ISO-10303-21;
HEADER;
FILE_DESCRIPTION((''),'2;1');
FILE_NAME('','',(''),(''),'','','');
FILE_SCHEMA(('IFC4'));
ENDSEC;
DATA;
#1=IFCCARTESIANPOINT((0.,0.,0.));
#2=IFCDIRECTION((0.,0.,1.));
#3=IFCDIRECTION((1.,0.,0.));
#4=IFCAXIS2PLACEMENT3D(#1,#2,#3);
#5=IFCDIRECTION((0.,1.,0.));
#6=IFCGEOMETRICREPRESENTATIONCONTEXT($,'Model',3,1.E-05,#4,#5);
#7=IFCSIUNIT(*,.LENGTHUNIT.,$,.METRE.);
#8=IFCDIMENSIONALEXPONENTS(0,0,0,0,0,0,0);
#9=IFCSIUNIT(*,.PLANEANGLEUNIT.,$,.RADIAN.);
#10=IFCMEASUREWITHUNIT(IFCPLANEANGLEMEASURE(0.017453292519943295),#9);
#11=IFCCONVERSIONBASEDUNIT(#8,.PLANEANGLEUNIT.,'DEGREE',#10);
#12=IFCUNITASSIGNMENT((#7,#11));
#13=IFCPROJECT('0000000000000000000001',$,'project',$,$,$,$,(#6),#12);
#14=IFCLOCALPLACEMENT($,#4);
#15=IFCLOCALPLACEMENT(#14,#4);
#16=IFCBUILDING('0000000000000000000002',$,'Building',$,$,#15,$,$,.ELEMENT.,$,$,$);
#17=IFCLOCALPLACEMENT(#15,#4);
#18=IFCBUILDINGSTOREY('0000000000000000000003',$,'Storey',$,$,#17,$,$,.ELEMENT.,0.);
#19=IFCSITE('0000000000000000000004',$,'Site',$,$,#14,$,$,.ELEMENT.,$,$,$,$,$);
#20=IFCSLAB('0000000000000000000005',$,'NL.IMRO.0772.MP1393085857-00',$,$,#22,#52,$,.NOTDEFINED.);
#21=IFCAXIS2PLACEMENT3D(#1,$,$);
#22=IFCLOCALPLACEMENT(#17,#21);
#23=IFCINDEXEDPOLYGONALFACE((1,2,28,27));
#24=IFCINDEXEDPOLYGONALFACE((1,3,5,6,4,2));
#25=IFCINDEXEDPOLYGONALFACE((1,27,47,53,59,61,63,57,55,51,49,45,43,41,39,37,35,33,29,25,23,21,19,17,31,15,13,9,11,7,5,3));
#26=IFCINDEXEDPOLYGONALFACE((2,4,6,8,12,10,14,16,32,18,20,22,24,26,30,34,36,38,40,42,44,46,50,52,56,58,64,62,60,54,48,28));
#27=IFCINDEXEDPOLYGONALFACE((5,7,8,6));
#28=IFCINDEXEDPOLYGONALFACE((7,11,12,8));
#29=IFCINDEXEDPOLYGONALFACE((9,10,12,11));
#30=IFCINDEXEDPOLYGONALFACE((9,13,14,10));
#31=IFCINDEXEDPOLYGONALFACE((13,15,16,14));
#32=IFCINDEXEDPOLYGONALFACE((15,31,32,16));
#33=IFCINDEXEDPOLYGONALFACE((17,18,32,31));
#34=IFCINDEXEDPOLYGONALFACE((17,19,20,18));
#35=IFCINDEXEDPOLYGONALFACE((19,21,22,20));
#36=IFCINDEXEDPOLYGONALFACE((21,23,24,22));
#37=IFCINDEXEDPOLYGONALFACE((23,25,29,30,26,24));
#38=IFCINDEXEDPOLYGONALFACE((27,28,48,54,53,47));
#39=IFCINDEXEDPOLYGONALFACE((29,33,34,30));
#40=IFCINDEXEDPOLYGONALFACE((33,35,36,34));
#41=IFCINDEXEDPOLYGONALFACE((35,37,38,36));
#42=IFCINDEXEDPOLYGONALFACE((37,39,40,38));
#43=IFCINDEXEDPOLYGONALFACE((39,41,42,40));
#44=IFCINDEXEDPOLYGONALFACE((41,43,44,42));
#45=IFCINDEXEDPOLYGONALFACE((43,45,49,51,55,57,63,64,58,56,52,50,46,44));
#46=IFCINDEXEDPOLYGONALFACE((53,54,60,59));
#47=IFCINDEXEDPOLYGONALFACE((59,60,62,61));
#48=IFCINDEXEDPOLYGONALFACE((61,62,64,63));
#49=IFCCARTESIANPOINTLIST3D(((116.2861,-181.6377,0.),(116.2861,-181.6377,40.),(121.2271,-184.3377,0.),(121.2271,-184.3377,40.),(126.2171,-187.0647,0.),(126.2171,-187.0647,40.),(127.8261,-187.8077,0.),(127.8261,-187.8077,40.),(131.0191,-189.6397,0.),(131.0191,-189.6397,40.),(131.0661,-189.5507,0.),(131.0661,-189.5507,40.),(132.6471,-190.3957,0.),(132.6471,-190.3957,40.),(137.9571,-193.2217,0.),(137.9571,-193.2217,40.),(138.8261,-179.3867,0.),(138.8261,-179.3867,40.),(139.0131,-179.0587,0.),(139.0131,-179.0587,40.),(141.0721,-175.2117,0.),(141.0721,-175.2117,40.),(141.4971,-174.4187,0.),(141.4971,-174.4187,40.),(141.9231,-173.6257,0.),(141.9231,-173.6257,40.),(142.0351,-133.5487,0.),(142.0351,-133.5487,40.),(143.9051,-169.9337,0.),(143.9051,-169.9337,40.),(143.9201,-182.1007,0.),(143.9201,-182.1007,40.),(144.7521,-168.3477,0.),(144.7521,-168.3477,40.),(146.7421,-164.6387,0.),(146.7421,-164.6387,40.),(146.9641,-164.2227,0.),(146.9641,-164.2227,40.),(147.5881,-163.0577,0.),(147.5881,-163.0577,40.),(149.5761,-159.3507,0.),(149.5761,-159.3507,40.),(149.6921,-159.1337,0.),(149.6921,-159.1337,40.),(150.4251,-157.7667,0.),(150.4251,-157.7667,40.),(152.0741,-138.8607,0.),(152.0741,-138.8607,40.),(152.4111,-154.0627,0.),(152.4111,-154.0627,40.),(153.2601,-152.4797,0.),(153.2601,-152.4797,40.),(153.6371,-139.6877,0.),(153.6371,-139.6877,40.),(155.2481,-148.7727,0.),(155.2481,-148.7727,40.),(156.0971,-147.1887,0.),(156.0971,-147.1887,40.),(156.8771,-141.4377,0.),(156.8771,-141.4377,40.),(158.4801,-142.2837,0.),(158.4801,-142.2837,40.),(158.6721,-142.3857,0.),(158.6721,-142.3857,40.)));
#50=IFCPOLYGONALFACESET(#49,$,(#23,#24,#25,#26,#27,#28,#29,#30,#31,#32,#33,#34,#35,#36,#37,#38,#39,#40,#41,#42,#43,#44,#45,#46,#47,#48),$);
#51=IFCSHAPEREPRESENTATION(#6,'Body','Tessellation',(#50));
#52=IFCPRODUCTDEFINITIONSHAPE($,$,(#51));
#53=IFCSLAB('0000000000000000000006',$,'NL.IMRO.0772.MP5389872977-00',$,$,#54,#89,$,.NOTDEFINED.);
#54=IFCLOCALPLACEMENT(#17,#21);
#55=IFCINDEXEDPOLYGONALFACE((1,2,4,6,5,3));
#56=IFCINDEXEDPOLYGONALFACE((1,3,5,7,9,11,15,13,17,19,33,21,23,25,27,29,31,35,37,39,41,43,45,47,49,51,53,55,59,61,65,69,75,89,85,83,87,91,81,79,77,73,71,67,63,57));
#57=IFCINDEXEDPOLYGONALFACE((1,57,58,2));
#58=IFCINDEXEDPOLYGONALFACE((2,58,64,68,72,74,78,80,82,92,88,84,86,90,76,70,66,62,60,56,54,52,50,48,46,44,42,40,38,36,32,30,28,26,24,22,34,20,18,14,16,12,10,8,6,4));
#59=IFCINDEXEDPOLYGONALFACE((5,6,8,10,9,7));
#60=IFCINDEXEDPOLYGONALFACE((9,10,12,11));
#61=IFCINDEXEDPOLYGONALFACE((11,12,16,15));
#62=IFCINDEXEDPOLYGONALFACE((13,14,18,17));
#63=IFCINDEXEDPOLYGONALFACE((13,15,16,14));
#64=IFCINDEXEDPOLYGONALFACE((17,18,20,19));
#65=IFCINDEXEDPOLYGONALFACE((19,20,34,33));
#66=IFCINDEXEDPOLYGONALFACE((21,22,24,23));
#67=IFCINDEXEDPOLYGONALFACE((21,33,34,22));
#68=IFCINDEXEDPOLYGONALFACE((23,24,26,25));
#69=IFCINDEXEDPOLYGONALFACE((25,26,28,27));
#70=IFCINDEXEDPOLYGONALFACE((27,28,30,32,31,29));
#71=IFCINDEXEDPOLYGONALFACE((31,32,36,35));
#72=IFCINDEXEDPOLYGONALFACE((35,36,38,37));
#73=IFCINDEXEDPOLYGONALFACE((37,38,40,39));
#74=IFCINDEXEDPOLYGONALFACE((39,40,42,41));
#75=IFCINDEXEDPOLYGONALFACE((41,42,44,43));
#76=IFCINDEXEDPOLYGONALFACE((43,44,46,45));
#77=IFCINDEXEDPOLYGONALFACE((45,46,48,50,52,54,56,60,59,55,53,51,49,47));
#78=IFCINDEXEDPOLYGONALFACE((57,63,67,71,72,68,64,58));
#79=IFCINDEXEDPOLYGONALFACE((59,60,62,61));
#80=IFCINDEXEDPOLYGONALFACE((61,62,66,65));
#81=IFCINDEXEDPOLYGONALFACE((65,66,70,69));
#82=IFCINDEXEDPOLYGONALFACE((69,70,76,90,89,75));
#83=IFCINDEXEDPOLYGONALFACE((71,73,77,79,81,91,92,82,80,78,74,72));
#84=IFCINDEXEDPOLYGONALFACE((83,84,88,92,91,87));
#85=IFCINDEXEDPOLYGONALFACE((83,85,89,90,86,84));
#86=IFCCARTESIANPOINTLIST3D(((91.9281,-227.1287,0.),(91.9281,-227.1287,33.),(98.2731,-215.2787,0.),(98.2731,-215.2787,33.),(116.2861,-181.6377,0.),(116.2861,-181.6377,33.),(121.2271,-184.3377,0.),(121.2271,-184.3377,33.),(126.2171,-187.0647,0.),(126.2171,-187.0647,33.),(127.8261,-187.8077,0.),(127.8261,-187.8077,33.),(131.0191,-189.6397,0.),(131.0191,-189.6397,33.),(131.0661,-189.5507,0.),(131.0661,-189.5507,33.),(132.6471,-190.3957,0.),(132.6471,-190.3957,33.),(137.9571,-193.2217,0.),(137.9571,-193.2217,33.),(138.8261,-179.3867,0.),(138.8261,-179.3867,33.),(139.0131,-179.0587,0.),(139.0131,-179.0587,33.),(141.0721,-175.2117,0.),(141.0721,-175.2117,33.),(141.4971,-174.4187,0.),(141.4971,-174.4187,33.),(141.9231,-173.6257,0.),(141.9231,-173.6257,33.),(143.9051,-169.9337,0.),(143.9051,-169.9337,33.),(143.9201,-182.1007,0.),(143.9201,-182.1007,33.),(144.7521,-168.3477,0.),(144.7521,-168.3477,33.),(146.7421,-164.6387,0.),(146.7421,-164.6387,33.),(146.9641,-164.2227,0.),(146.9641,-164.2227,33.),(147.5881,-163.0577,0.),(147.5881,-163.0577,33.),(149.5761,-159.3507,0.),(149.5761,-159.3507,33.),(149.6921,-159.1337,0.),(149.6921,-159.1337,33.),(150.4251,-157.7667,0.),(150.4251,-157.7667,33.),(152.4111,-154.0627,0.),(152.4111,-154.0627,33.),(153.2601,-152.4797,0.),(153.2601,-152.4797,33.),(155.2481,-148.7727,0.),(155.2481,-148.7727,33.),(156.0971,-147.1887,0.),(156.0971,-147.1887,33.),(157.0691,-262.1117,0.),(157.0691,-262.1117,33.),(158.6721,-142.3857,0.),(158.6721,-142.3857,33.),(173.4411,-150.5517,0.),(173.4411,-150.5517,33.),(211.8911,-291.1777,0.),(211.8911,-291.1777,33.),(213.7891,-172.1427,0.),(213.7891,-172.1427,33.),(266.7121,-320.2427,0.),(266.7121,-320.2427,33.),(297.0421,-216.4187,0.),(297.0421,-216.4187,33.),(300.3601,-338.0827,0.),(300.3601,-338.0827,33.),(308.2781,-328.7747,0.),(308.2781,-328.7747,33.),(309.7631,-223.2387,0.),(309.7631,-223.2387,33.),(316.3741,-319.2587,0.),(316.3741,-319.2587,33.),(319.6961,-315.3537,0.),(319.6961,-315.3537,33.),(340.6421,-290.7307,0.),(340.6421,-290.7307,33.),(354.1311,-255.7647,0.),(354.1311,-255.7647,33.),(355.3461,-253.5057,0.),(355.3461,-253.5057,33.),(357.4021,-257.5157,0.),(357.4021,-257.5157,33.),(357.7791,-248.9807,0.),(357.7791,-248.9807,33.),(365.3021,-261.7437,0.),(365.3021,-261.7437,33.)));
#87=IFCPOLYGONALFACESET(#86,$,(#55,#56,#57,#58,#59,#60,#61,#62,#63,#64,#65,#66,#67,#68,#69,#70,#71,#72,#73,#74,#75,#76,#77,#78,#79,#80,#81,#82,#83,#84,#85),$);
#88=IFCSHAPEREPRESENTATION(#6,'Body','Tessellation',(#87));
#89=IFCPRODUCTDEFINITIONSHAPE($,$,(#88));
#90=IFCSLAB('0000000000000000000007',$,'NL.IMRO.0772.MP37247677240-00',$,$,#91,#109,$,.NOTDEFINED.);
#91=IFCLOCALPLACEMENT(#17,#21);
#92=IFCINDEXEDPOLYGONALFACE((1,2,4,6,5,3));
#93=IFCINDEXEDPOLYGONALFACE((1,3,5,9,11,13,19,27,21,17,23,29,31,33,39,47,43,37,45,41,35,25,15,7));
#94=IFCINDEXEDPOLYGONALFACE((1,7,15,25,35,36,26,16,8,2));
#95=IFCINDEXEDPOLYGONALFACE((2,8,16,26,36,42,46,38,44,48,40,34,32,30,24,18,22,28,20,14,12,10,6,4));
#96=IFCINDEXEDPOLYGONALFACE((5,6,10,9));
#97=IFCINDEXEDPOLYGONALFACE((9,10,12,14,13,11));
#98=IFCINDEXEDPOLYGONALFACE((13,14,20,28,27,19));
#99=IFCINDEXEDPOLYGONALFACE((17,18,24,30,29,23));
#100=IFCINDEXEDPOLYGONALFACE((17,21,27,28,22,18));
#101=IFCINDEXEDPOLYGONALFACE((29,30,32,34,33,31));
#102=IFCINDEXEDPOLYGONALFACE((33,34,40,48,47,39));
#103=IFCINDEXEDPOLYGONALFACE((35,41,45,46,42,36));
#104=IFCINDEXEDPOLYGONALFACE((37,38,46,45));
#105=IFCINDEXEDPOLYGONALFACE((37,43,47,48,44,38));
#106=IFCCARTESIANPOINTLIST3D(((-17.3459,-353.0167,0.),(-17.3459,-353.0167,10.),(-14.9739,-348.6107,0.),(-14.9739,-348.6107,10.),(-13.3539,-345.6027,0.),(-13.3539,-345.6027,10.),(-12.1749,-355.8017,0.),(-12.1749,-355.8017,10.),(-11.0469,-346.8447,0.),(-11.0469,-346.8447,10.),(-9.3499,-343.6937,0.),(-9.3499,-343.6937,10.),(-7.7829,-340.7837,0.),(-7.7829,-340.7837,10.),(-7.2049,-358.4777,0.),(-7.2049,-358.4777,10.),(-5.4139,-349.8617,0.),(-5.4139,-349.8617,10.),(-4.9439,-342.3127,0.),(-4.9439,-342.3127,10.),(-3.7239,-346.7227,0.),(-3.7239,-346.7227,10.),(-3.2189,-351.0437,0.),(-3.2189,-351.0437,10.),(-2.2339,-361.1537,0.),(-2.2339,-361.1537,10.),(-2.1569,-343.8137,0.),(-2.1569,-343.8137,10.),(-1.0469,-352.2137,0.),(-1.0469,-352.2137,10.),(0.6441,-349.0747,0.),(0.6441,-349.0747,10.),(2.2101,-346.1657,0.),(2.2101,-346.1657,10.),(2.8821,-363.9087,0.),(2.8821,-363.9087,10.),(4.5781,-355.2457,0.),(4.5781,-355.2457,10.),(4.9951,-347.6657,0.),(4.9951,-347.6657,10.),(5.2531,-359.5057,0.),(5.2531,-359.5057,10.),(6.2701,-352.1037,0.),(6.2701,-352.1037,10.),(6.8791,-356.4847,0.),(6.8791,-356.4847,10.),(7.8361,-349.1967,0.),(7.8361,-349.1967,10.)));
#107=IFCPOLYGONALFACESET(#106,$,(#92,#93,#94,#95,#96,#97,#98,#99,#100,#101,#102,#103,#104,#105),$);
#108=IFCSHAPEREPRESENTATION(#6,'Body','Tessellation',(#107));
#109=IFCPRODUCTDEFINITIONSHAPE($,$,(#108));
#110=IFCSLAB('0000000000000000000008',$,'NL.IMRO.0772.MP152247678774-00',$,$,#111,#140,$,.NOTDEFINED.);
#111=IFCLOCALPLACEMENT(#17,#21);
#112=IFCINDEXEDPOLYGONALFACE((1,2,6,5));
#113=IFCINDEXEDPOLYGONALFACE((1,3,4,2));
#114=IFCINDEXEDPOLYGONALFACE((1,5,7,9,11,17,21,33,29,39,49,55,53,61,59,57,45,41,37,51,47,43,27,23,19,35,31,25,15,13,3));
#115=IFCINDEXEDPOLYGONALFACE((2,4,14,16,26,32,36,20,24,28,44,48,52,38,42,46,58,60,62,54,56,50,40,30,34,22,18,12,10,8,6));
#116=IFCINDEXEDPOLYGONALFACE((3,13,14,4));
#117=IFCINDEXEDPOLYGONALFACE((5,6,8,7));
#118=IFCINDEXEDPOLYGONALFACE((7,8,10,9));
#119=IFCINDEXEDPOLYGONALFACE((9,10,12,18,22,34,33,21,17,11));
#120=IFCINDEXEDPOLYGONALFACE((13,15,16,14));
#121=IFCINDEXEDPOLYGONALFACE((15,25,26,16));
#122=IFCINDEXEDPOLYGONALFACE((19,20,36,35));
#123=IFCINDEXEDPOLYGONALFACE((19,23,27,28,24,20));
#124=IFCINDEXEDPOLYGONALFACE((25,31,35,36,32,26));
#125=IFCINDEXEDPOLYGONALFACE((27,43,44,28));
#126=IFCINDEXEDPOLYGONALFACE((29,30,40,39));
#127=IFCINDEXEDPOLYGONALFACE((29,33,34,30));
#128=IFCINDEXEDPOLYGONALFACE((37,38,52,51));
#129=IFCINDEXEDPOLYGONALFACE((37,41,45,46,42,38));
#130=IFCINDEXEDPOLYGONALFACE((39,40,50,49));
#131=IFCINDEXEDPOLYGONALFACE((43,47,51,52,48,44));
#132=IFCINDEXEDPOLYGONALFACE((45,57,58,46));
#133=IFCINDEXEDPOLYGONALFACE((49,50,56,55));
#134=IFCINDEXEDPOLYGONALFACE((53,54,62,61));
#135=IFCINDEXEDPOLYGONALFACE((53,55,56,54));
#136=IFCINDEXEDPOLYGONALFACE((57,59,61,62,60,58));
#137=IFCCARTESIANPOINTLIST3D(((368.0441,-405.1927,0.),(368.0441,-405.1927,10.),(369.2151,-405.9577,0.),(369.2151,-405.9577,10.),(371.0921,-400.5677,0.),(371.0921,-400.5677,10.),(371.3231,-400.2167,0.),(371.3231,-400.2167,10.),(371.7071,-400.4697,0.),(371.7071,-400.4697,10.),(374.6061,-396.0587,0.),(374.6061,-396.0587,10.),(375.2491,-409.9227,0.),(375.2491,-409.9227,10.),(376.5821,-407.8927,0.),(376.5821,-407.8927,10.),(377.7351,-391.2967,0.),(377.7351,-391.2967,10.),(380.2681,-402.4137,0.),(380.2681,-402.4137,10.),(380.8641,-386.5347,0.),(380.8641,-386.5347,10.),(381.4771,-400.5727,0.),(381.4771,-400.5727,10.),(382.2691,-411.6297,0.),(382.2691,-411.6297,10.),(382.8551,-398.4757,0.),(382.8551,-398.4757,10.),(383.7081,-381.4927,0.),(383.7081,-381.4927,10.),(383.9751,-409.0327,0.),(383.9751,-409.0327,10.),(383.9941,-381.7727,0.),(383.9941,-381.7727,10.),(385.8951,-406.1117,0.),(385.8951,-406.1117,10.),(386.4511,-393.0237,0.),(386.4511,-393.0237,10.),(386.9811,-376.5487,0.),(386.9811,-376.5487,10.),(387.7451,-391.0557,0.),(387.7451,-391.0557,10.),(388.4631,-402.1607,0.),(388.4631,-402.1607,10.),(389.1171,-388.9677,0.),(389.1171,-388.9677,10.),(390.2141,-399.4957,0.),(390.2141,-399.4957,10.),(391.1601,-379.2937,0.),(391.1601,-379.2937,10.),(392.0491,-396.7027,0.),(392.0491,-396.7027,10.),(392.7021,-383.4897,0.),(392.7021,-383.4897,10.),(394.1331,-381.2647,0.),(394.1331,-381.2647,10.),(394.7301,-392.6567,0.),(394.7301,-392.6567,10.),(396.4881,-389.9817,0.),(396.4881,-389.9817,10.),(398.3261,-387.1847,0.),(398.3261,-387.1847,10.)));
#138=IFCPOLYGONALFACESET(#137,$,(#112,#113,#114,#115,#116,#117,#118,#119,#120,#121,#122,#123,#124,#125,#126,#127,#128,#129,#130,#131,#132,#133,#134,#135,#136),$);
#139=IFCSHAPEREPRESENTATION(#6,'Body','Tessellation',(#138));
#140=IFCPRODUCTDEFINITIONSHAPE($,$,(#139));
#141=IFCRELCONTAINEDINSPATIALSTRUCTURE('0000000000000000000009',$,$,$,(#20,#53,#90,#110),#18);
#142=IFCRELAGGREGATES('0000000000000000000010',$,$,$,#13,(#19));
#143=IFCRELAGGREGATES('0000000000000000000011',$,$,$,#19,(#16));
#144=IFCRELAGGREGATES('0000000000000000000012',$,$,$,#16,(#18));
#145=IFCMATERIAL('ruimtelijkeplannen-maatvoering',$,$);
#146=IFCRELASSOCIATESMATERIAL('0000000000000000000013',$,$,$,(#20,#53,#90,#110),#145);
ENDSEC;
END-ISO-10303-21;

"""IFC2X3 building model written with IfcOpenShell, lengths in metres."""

from ifc_helpers import new_model, entity, si_unit, converted_unit, direction, origin_with_axes, place, context, project, spatial, polyline, outline, extrude, material, element, save


model = new_model("IFC2X3")

# Units and contexts
model_context = context("Model", 3, precision=1e-05, world=origin_with_axes(), true_north=direction((0.0, 1.0, 0.0)))
ifc_project = project(units=[si_unit("LENGTHUNIT", "METRE"), converted_unit("PLANEANGLEUNIT", "DEGREE", entity("IfcPlaneAngleMeasure", 0.017453292519943295), si_unit("PLANEANGLEUNIT", "RADIAN"), dimensions=[0, 0, 0, 0, 0, 0, 0])], contexts=[model_context])

# Site, building, storey
site_placement = place(None, origin_with_axes())
site = spatial("IfcSite", under=ifc_project, at=site_placement, Name="Site", CompositionType="ELEMENT")
building_placement = place(site_placement, origin_with_axes())
building = spatial("IfcBuilding", under=site, at=building_placement, Name="Building", CompositionType="ELEMENT")
storey_placement = place(building_placement, origin_with_axes())
storey = spatial("IfcBuildingStorey", under=building, at=storey_placement, Name="Storey", CompositionType="ELEMENT", Elevation=0.0)

# Slabs
ifc_material = material(Name="ruimtelijkeplannen-maatvoering")
slab_1_placement = place(storey_placement, origin_with_axes())
element("IfcSlab", 1, at=slab_1_placement, inside=storey, material=ifc_material, Name="NL.IMRO.0772.MP1393085857-00", PredefinedType="NOTDEFINED", context=model_context, shape_type="SweptSolid", body=[
    extrude(outline(polyline([(116.2861, -181.6377), (142.0351, -133.5487), (152.0741, -138.8607), (153.6371, -139.6877), (156.8771, -141.4377), (158.4801, -142.2837), (158.6721, -142.3857), (156.0971, -147.1887), (155.2481, -148.7727), (153.2601, -152.4797), (152.4111, -154.0627), (150.4251, -157.7667), (149.6921, -159.1337), (149.5761, -159.3507), (147.5881, -163.0577), (146.9641, -164.2227), (146.7421, -164.6387), (144.7521, -168.3477), (143.9051, -169.9337), (141.9231, -173.6257), (141.4971, -174.4187), (141.0721, -175.2117), (139.0131, -179.0587), (138.8261, -179.3867), (143.9201, -182.1007), (137.9571, -193.2217), (132.6471, -190.3957), (131.0191, -189.6397), (131.0661, -189.5507), (127.8261, -187.8077), (126.2171, -187.0647), (121.2271, -184.3377), (116.2861, -181.6377)])), origin_with_axes(), (0.0, 0.0, 1.0), 40.0),
])
slab_2_placement = place(storey_placement, origin_with_axes())
element("IfcSlab", 2, at=slab_2_placement, inside=storey, material=ifc_material, Name="NL.IMRO.0772.MP5389872977-00", PredefinedType="NOTDEFINED", context=model_context, shape_type="SweptSolid", body=[
    extrude(outline(polyline([(98.2731, -215.2787), (116.2861, -181.6377), (121.2271, -184.3377), (126.2171, -187.0647), (127.8261, -187.8077), (131.0661, -189.5507), (131.0191, -189.6397), (132.6471, -190.3957), (137.9571, -193.2217), (143.9201, -182.1007), (138.8261, -179.3867), (139.0131, -179.0587), (141.0721, -175.2117), (141.4971, -174.4187), (141.9231, -173.6257), (143.9051, -169.9337), (144.7521, -168.3477), (146.7421, -164.6387), (146.9641, -164.2227), (147.5881, -163.0577), (149.5761, -159.3507), (149.6921, -159.1337), (150.4251, -157.7667), (152.4111, -154.0627), (153.2601, -152.4797), (155.2481, -148.7727), (156.0971, -147.1887), (158.6721, -142.3857), (173.4411, -150.5517), (213.7891, -172.1427), (297.0421, -216.4187), (309.7631, -223.2387), (357.7791, -248.9807), (355.3461, -253.5057), (354.1311, -255.7647), (357.4021, -257.5157), (365.3021, -261.7437), (340.6421, -290.7307), (319.6961, -315.3537), (316.3741, -319.2587), (308.2781, -328.7747), (300.3601, -338.0827), (266.7121, -320.2427), (211.8911, -291.1777), (157.0691, -262.1117), (91.9281, -227.1287), (98.2731, -215.2787)])), origin_with_axes(), (0.0, 0.0, 1.0), 33.0),
])
slab_3_placement = place(storey_placement, origin_with_axes())
element("IfcSlab", 3, at=slab_3_placement, inside=storey, material=ifc_material, Name="NL.IMRO.0772.MP37247677240-00", PredefinedType="NOTDEFINED", context=model_context, shape_type="SweptSolid", body=[
    extrude(outline(polyline([(6.8791, -356.4847), (5.2531, -359.5057), (2.8821, -363.9087), (-2.2339, -361.1537), (-7.2049, -358.4777), (-12.1749, -355.8017), (-17.3459, -353.0167), (-14.9739, -348.6107), (-13.3539, -345.6027), (-11.0469, -346.8447), (-9.3499, -343.6937), (-7.7829, -340.7837), (-4.9439, -342.3127), (-2.1569, -343.8137), (-3.7239, -346.7227), (-5.4139, -349.8617), (-3.2189, -351.0437), (-1.0469, -352.2137), (0.6441, -349.0747), (2.2101, -346.1657), (4.9951, -347.6657), (7.8361, -349.1967), (6.2701, -352.1037), (4.5781, -355.2457), (6.8791, -356.4847)])), origin_with_axes(), (0.0, 0.0, 1.0), 10.0),
])
slab_4_placement = place(storey_placement, origin_with_axes())
element("IfcSlab", 4, at=slab_4_placement, inside=storey, material=ifc_material, Name="NL.IMRO.0772.MP152247678774-00", PredefinedType="NOTDEFINED", context=model_context, shape_type="SweptSolid", body=[
    extrude(outline(polyline([(383.9941, -381.7727), (383.7081, -381.4927), (386.9811, -376.5487), (391.1601, -379.2937), (394.1331, -381.2647), (392.7021, -383.4897), (398.3261, -387.1847), (396.4881, -389.9817), (394.7301, -392.6567), (389.1171, -388.9677), (387.7451, -391.0557), (386.4511, -393.0237), (392.0491, -396.7027), (390.2141, -399.4957), (388.4631, -402.1607), (382.8551, -398.4757), (381.4771, -400.5727), (380.2681, -402.4137), (385.8951, -406.1117), (383.9751, -409.0327), (382.2691, -411.6297), (376.5821, -407.8927), (375.2491, -409.9227), (369.2151, -405.9577), (368.0441, -405.1927), (371.0921, -400.5677), (371.3231, -400.2167), (371.7071, -400.4697), (374.6061, -396.0587), (377.7351, -391.2967), (380.8641, -386.5347), (383.9941, -381.7727)])), origin_with_axes(), (0.0, 0.0, 1.0), 10.0),
])

save(model, "model.ifc")
